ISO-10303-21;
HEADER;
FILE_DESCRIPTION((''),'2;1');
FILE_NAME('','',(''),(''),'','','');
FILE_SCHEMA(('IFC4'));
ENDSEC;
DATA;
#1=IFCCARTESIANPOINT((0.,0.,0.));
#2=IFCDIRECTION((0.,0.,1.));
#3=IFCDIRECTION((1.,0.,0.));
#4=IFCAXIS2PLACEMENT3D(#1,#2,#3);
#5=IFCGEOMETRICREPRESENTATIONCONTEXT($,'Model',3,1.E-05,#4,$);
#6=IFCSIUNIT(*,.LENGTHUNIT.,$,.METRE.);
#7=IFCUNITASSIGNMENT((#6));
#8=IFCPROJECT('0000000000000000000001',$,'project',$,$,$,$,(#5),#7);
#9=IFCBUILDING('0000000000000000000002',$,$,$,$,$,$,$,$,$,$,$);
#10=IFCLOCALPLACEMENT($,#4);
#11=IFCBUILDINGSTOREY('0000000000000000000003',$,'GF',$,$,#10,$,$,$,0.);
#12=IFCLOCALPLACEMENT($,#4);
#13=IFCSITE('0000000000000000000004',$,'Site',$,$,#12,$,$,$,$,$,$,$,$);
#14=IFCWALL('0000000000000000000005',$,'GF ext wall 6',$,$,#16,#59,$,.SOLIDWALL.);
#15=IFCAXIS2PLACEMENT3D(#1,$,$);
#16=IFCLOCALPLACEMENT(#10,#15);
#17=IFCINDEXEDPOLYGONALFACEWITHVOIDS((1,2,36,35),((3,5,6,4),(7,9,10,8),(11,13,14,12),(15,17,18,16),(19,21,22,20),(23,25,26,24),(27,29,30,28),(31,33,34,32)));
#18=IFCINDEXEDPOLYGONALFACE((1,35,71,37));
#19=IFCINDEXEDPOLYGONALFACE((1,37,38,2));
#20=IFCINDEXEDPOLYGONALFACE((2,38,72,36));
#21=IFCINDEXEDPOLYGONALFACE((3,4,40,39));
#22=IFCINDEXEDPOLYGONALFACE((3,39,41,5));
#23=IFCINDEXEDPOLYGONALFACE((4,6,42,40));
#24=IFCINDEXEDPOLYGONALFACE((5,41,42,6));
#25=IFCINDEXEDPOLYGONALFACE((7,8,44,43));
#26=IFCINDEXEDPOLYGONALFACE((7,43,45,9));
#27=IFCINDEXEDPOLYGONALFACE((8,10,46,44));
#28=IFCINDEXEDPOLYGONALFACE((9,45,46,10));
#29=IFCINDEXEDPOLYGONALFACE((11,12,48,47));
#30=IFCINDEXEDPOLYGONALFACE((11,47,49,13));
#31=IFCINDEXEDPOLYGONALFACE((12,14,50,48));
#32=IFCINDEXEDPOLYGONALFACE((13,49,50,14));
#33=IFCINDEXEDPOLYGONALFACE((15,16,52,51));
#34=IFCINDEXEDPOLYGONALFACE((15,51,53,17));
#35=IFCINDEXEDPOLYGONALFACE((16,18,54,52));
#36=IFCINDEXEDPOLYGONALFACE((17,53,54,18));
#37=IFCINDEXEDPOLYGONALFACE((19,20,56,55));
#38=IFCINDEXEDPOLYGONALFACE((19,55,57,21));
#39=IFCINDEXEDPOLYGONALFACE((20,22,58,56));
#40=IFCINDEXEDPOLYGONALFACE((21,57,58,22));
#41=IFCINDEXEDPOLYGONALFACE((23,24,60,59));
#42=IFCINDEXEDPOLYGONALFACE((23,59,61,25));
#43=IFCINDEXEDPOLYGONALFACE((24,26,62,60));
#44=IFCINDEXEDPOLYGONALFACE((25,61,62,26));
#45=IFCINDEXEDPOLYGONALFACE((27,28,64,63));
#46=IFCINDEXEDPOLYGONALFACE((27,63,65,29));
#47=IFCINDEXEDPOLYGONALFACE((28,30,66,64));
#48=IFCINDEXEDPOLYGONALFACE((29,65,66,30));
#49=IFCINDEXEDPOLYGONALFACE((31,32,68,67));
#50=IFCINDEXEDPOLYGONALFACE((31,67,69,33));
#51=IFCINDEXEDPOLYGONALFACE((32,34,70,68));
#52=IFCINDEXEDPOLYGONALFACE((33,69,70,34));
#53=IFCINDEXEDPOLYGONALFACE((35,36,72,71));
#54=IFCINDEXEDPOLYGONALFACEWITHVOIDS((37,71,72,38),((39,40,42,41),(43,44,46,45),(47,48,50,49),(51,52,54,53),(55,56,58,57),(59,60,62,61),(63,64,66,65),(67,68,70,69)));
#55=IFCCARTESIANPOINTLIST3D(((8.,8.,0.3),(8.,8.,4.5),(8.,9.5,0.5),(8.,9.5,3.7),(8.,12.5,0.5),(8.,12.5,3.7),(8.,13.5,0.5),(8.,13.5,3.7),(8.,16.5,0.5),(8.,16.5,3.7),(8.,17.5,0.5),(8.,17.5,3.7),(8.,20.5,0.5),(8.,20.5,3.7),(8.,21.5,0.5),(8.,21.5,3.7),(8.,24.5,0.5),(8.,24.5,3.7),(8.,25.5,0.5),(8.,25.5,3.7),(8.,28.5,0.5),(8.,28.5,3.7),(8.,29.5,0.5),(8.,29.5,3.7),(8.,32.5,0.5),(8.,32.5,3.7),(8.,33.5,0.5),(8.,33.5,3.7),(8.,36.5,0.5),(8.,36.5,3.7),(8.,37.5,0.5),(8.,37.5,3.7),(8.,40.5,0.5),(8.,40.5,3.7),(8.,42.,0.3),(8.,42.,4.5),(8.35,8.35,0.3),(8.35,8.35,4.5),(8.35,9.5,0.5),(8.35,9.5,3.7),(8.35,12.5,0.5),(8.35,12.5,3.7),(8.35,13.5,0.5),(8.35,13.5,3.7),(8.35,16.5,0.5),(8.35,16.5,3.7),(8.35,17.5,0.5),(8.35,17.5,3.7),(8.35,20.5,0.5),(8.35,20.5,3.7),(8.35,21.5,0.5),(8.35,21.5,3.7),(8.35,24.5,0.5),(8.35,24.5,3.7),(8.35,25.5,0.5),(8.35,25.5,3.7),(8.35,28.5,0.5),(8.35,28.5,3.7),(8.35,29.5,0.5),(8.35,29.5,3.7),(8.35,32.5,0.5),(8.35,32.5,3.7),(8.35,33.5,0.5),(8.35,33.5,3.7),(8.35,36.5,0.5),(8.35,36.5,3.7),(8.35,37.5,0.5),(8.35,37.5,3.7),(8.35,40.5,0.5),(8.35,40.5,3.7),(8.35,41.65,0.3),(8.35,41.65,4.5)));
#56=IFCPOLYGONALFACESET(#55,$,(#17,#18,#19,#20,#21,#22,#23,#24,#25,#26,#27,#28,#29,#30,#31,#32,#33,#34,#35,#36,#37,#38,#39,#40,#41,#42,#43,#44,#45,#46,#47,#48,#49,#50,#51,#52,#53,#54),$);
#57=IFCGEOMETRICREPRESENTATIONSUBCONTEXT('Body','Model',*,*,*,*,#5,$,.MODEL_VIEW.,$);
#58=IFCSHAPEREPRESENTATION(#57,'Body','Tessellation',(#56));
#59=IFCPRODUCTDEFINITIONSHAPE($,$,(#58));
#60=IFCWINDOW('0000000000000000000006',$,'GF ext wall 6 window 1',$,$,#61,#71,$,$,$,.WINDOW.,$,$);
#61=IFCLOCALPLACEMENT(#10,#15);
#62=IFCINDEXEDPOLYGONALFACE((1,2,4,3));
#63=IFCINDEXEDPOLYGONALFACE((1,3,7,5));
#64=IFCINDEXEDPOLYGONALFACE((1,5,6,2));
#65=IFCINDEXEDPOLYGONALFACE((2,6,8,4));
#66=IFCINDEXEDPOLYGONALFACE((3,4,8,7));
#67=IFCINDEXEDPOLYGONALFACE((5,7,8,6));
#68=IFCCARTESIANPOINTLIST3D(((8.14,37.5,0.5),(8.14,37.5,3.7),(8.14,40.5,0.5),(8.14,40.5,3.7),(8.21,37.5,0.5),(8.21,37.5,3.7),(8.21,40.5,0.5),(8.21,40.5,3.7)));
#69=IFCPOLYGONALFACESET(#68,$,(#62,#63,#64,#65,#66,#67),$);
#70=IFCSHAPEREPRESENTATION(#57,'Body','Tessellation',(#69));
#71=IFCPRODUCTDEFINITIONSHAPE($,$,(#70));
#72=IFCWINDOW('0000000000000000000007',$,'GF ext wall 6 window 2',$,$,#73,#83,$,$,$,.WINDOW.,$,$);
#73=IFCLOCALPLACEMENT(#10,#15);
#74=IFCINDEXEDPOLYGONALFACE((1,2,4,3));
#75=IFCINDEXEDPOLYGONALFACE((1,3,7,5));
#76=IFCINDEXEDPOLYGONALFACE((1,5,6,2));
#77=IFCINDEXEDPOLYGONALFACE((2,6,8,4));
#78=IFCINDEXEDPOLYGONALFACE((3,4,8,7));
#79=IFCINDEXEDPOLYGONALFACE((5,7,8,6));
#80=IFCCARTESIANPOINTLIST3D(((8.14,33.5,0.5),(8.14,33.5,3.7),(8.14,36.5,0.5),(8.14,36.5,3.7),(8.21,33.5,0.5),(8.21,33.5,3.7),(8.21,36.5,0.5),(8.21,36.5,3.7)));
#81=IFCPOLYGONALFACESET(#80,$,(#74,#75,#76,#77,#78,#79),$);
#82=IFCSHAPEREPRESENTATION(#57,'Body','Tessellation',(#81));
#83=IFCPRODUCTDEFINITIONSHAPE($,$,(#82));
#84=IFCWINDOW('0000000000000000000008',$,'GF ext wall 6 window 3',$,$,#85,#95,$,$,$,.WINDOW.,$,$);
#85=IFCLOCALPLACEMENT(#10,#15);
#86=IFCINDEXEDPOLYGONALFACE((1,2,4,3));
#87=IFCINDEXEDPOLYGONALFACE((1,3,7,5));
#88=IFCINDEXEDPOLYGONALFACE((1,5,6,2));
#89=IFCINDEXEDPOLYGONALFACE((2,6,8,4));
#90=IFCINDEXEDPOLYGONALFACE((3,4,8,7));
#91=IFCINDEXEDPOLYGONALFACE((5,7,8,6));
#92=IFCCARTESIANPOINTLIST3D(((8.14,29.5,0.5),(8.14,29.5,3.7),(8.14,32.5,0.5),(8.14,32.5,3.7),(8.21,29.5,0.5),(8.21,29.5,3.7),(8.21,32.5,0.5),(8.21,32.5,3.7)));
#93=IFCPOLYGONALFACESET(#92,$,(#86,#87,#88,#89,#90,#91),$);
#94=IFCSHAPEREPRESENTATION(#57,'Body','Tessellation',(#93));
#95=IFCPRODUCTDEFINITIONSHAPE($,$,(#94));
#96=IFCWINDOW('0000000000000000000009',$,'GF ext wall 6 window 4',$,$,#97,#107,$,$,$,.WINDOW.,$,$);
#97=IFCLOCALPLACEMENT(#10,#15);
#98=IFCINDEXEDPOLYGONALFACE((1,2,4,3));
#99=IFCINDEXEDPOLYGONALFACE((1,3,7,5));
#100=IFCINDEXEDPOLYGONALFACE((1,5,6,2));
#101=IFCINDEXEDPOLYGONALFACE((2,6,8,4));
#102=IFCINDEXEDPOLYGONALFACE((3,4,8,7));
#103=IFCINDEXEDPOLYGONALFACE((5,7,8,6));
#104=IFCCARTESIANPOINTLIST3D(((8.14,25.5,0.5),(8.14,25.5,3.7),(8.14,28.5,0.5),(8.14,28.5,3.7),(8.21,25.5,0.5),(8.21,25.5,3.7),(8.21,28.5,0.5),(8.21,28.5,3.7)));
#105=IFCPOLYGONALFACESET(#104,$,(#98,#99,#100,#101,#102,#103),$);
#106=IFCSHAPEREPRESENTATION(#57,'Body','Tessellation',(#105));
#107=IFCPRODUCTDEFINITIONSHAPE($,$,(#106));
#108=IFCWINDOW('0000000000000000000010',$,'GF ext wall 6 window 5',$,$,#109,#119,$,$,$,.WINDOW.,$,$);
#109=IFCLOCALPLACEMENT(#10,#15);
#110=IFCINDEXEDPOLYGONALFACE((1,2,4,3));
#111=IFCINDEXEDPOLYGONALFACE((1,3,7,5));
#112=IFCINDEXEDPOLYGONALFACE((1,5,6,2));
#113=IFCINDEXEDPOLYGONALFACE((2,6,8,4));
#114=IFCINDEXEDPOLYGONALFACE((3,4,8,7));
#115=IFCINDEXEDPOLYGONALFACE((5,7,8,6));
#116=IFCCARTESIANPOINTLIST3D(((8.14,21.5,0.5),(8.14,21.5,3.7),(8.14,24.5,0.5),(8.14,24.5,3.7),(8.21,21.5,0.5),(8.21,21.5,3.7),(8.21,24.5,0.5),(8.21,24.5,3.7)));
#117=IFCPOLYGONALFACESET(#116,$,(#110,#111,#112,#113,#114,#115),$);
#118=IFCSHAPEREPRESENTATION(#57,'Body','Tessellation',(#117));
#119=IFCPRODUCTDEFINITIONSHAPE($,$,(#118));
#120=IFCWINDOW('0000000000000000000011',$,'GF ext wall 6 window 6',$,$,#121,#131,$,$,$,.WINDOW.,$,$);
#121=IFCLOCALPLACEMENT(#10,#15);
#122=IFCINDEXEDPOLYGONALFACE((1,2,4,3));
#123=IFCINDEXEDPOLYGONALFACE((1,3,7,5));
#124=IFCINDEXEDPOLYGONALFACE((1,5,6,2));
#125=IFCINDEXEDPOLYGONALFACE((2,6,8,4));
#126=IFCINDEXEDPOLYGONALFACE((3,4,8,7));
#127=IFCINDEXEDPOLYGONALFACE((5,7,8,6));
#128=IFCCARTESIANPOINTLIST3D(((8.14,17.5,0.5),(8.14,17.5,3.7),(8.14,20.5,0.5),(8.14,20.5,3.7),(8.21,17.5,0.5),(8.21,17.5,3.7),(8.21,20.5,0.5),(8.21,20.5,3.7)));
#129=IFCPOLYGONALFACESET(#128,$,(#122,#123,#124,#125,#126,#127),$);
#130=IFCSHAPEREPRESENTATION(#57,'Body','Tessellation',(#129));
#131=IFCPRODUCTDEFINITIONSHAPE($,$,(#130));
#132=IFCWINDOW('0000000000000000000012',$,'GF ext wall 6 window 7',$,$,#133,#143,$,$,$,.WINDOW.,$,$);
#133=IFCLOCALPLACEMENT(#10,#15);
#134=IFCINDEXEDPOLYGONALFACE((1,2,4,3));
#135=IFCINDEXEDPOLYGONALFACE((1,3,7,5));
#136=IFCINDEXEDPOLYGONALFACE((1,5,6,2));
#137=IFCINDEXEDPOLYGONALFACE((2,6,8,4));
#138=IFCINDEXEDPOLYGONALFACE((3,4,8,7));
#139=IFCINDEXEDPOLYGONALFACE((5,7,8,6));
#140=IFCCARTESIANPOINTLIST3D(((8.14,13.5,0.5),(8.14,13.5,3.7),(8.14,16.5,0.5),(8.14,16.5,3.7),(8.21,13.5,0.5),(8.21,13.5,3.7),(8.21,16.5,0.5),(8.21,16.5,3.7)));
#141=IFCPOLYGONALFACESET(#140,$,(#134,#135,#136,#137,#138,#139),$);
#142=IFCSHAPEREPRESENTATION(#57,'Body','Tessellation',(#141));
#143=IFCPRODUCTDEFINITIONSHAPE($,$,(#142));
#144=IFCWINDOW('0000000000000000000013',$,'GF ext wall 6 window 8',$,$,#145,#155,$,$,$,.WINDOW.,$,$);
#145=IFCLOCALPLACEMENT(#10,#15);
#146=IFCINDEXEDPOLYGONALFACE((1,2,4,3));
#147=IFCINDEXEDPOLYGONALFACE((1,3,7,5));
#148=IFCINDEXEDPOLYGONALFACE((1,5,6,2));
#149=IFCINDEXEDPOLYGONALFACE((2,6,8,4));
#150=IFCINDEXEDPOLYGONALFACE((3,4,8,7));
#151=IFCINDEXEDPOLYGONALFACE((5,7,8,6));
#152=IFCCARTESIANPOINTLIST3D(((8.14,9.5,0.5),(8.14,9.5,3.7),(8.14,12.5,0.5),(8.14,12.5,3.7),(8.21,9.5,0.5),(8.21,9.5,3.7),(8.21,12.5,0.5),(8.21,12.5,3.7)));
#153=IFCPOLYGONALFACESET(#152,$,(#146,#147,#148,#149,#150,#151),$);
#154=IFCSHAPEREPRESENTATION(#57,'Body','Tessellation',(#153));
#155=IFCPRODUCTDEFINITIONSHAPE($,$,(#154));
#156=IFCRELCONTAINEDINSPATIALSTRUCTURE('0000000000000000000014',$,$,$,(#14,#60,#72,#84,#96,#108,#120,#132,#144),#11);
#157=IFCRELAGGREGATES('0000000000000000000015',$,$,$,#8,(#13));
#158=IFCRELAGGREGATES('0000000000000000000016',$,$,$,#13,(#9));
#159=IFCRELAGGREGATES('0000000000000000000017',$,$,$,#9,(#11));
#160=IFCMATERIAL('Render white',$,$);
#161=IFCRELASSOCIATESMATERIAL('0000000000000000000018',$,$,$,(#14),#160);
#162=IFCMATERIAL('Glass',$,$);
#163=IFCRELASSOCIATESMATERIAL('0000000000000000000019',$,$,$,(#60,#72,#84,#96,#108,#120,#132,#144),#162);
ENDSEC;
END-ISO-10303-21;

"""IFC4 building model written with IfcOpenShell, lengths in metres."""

from ifc_helpers import new_model, si_unit, frame, origin_with_axes, place, context, subcontext, project, spatial, polyline, outline, extrude, material, element, fill, save


model = new_model("IFC4")

# Units and contexts
model_context = context("Model", 3, precision=1e-05, world=origin_with_axes())
body_context = subcontext(model_context, "Body", "Model", "MODEL_VIEW")
ifc_project = project(units=[si_unit("LENGTHUNIT", "METRE")], contexts=[model_context])

# Site, building, storey
site_placement = place(None, origin_with_axes())
site = spatial("IfcSite", under=ifc_project, at=site_placement, Name="Site")
building = spatial("IfcBuilding", under=site)
storey_placement = place(None, origin_with_axes())
storey = spatial("IfcBuildingStorey", under=building, at=storey_placement, Name="GF", Elevation=0.0)

# Wall, openings, windows
ifc_material_1 = material(Name="Render white")
ifc_material_2 = material(Name="Glass")
wall_1_placement = place(storey_placement, origin_with_axes())
wall_1 = element("IfcWall", 1, at=wall_1_placement, inside=storey, material=ifc_material_1, Name="GF ext wall 6", PredefinedType="SOLIDWALL", context=body_context, shape_type="SweptSolid", body=[
    extrude(outline(polyline([(8.0, 42.0), (8.0, 8.0), (8.35, 8.35), (8.35, 41.65), (8.0, 42.0)])), frame((0.0, 0.0, 0.3), z_axis=(0.0, 0.0, 1.0), x_axis=(1.0, 0.0, 0.0)), (0.0, 0.0, 1.0), 4.2),
])
opening_1_placement = place(wall_1_placement, origin_with_axes())
opening_1 = element("IfcOpeningElement", 2, at=opening_1_placement, cuts=wall_1, context=body_context, shape_type="SweptSolid", body=[
    extrude(outline(polyline([(7.95, 40.5), (7.95, 37.5), (8.4, 37.5), (8.4, 40.5), (7.95, 40.5)])), frame((0.0, 0.0, 0.5), z_axis=(0.0, 0.0, 1.0), x_axis=(1.0, 0.0, 0.0)), (0.0, 0.0, 1.0), 3.2),
])
opening_2_placement = place(wall_1_placement, origin_with_axes())
opening_2 = element("IfcOpeningElement", 3, at=opening_2_placement, cuts=wall_1, context=body_context, shape_type="SweptSolid", body=[
    extrude(outline(polyline([(7.95, 36.5), (7.95, 33.5), (8.4, 33.5), (8.4, 36.5), (7.95, 36.5)])), frame((0.0, 0.0, 0.5), z_axis=(0.0, 0.0, 1.0), x_axis=(1.0, 0.0, 0.0)), (0.0, 0.0, 1.0), 3.2),
])
opening_3_placement = place(wall_1_placement, origin_with_axes())
opening_3 = element("IfcOpeningElement", 4, at=opening_3_placement, cuts=wall_1, context=body_context, shape_type="SweptSolid", body=[
    extrude(outline(polyline([(7.95, 32.5), (7.95, 29.5), (8.4, 29.5), (8.4, 32.5), (7.95, 32.5)])), frame((0.0, 0.0, 0.5), z_axis=(0.0, 0.0, 1.0), x_axis=(1.0, 0.0, 0.0)), (0.0, 0.0, 1.0), 3.2),
])
opening_4_placement = place(wall_1_placement, origin_with_axes())
opening_4 = element("IfcOpeningElement", 5, at=opening_4_placement, cuts=wall_1, context=body_context, shape_type="SweptSolid", body=[
    extrude(outline(polyline([(7.95, 28.5), (7.95, 25.5), (8.4, 25.5), (8.4, 28.5), (7.95, 28.5)])), frame((0.0, 0.0, 0.5), z_axis=(0.0, 0.0, 1.0), x_axis=(1.0, 0.0, 0.0)), (0.0, 0.0, 1.0), 3.2),
])
opening_5_placement = place(wall_1_placement, origin_with_axes())
opening_5 = element("IfcOpeningElement", 6, at=opening_5_placement, cuts=wall_1, context=body_context, shape_type="SweptSolid", body=[
    extrude(outline(polyline([(7.95, 24.5), (7.95, 21.5), (8.4, 21.5), (8.4, 24.5), (7.95, 24.5)])), frame((0.0, 0.0, 0.5), z_axis=(0.0, 0.0, 1.0), x_axis=(1.0, 0.0, 0.0)), (0.0, 0.0, 1.0), 3.2),
])
opening_6_placement = place(wall_1_placement, origin_with_axes())
opening_6 = element("IfcOpeningElement", 7, at=opening_6_placement, cuts=wall_1, context=body_context, shape_type="SweptSolid", body=[
    extrude(outline(polyline([(7.95, 20.5), (7.95, 17.5), (8.4, 17.5), (8.4, 20.5), (7.95, 20.5)])), frame((0.0, 0.0, 0.5), z_axis=(0.0, 0.0, 1.0), x_axis=(1.0, 0.0, 0.0)), (0.0, 0.0, 1.0), 3.2),
])
opening_7_placement = place(wall_1_placement, origin_with_axes())
opening_7 = element("IfcOpeningElement", 8, at=opening_7_placement, cuts=wall_1, context=body_context, shape_type="SweptSolid", body=[
    extrude(outline(polyline([(7.95, 16.5), (7.95, 13.5), (8.4, 13.5), (8.4, 16.5), (7.95, 16.5)])), frame((0.0, 0.0, 0.5), z_axis=(0.0, 0.0, 1.0), x_axis=(1.0, 0.0, 0.0)), (0.0, 0.0, 1.0), 3.2),
])
opening_8_placement = place(wall_1_placement, origin_with_axes())
opening_8 = element("IfcOpeningElement", 9, at=opening_8_placement, cuts=wall_1, context=body_context, shape_type="SweptSolid", body=[
    extrude(outline(polyline([(7.95, 12.5), (7.95, 9.5), (8.4, 9.5), (8.4, 12.5), (7.95, 12.5)])), frame((0.0, 0.0, 0.5), z_axis=(0.0, 0.0, 1.0), x_axis=(1.0, 0.0, 0.0)), (0.0, 0.0, 1.0), 3.2),
])
window_1_placement = place(storey_placement, origin_with_axes())
window_1 = element("IfcWindow", 10, at=window_1_placement, inside=storey, material=ifc_material_2, Name="GF ext wall 6 window 1", PredefinedType="WINDOW", context=body_context, shape_type="SweptSolid", body=[
    extrude(outline(polyline([(8.14, 40.5), (8.14, 37.5), (8.21, 37.5), (8.21, 40.5), (8.14, 40.5)])), frame((0.0, 0.0, 0.5), z_axis=(0.0, 0.0, 1.0), x_axis=(1.0, 0.0, 0.0)), (0.0, 0.0, 1.0), 3.2),
])
fill(opening_1, window_1)
window_2_placement = place(storey_placement, origin_with_axes())
window_2 = element("IfcWindow", 11, at=window_2_placement, inside=storey, material=ifc_material_2, Name="GF ext wall 6 window 2", PredefinedType="WINDOW", context=body_context, shape_type="SweptSolid", body=[
    extrude(outline(polyline([(8.14, 36.5), (8.14, 33.5), (8.21, 33.5), (8.21, 36.5), (8.14, 36.5)])), frame((0.0, 0.0, 0.5), z_axis=(0.0, 0.0, 1.0), x_axis=(1.0, 0.0, 0.0)), (0.0, 0.0, 1.0), 3.2),
])
fill(opening_2, window_2)
window_3_placement = place(storey_placement, origin_with_axes())
window_3 = element("IfcWindow", 12, at=window_3_placement, inside=storey, material=ifc_material_2, Name="GF ext wall 6 window 3", PredefinedType="WINDOW", context=body_context, shape_type="SweptSolid", body=[
    extrude(outline(polyline([(8.14, 32.5), (8.14, 29.5), (8.21, 29.5), (8.21, 32.5), (8.14, 32.5)])), frame((0.0, 0.0, 0.5), z_axis=(0.0, 0.0, 1.0), x_axis=(1.0, 0.0, 0.0)), (0.0, 0.0, 1.0), 3.2),
])
fill(opening_3, window_3)
window_4_placement = place(storey_placement, origin_with_axes())
window_4 = element("IfcWindow", 13, at=window_4_placement, inside=storey, material=ifc_material_2, Name="GF ext wall 6 window 4", PredefinedType="WINDOW", context=body_context, shape_type="SweptSolid", body=[
    extrude(outline(polyline([(8.14, 28.5), (8.14, 25.5), (8.21, 25.5), (8.21, 28.5), (8.14, 28.5)])), frame((0.0, 0.0, 0.5), z_axis=(0.0, 0.0, 1.0), x_axis=(1.0, 0.0, 0.0)), (0.0, 0.0, 1.0), 3.2),
])
fill(opening_4, window_4)
window_5_placement = place(storey_placement, origin_with_axes())
window_5 = element("IfcWindow", 14, at=window_5_placement, inside=storey, material=ifc_material_2, Name="GF ext wall 6 window 5", PredefinedType="WINDOW", context=body_context, shape_type="SweptSolid", body=[
    extrude(outline(polyline([(8.14, 24.5), (8.14, 21.5), (8.21, 21.5), (8.21, 24.5), (8.14, 24.5)])), frame((0.0, 0.0, 0.5), z_axis=(0.0, 0.0, 1.0), x_axis=(1.0, 0.0, 0.0)), (0.0, 0.0, 1.0), 3.2),
])
fill(opening_5, window_5)
window_6_placement = place(storey_placement, origin_with_axes())
window_6 = element("IfcWindow", 15, at=window_6_placement, inside=storey, material=ifc_material_2, Name="GF ext wall 6 window 6", PredefinedType="WINDOW", context=body_context, shape_type="SweptSolid", body=[
    extrude(outline(polyline([(8.14, 20.5), (8.14, 17.5), (8.21, 17.5), (8.21, 20.5), (8.14, 20.5)])), frame((0.0, 0.0, 0.5), z_axis=(0.0, 0.0, 1.0), x_axis=(1.0, 0.0, 0.0)), (0.0, 0.0, 1.0), 3.2),
])
fill(opening_6, window_6)
window_7_placement = place(storey_placement, origin_with_axes())
window_7 = element("IfcWindow", 16, at=window_7_placement, inside=storey, material=ifc_material_2, Name="GF ext wall 6 window 7", PredefinedType="WINDOW", context=body_context, shape_type="SweptSolid", body=[
    extrude(outline(polyline([(8.14, 16.5), (8.14, 13.5), (8.21, 13.5), (8.21, 16.5), (8.14, 16.5)])), frame((0.0, 0.0, 0.5), z_axis=(0.0, 0.0, 1.0), x_axis=(1.0, 0.0, 0.0)), (0.0, 0.0, 1.0), 3.2),
])
fill(opening_7, window_7)
window_8_placement = place(storey_placement, origin_with_axes())
window_8 = element("IfcWindow", 17, at=window_8_placement, inside=storey, material=ifc_material_2, Name="GF ext wall 6 window 8", PredefinedType="WINDOW", context=body_context, shape_type="SweptSolid", body=[
    extrude(outline(polyline([(8.14, 12.5), (8.14, 9.5), (8.21, 9.5), (8.21, 12.5), (8.14, 12.5)])), frame((0.0, 0.0, 0.5), z_axis=(0.0, 0.0, 1.0), x_axis=(1.0, 0.0, 0.0)), (0.0, 0.0, 1.0), 3.2),
])
fill(opening_8, window_8)

save(model, "model.ifc")
